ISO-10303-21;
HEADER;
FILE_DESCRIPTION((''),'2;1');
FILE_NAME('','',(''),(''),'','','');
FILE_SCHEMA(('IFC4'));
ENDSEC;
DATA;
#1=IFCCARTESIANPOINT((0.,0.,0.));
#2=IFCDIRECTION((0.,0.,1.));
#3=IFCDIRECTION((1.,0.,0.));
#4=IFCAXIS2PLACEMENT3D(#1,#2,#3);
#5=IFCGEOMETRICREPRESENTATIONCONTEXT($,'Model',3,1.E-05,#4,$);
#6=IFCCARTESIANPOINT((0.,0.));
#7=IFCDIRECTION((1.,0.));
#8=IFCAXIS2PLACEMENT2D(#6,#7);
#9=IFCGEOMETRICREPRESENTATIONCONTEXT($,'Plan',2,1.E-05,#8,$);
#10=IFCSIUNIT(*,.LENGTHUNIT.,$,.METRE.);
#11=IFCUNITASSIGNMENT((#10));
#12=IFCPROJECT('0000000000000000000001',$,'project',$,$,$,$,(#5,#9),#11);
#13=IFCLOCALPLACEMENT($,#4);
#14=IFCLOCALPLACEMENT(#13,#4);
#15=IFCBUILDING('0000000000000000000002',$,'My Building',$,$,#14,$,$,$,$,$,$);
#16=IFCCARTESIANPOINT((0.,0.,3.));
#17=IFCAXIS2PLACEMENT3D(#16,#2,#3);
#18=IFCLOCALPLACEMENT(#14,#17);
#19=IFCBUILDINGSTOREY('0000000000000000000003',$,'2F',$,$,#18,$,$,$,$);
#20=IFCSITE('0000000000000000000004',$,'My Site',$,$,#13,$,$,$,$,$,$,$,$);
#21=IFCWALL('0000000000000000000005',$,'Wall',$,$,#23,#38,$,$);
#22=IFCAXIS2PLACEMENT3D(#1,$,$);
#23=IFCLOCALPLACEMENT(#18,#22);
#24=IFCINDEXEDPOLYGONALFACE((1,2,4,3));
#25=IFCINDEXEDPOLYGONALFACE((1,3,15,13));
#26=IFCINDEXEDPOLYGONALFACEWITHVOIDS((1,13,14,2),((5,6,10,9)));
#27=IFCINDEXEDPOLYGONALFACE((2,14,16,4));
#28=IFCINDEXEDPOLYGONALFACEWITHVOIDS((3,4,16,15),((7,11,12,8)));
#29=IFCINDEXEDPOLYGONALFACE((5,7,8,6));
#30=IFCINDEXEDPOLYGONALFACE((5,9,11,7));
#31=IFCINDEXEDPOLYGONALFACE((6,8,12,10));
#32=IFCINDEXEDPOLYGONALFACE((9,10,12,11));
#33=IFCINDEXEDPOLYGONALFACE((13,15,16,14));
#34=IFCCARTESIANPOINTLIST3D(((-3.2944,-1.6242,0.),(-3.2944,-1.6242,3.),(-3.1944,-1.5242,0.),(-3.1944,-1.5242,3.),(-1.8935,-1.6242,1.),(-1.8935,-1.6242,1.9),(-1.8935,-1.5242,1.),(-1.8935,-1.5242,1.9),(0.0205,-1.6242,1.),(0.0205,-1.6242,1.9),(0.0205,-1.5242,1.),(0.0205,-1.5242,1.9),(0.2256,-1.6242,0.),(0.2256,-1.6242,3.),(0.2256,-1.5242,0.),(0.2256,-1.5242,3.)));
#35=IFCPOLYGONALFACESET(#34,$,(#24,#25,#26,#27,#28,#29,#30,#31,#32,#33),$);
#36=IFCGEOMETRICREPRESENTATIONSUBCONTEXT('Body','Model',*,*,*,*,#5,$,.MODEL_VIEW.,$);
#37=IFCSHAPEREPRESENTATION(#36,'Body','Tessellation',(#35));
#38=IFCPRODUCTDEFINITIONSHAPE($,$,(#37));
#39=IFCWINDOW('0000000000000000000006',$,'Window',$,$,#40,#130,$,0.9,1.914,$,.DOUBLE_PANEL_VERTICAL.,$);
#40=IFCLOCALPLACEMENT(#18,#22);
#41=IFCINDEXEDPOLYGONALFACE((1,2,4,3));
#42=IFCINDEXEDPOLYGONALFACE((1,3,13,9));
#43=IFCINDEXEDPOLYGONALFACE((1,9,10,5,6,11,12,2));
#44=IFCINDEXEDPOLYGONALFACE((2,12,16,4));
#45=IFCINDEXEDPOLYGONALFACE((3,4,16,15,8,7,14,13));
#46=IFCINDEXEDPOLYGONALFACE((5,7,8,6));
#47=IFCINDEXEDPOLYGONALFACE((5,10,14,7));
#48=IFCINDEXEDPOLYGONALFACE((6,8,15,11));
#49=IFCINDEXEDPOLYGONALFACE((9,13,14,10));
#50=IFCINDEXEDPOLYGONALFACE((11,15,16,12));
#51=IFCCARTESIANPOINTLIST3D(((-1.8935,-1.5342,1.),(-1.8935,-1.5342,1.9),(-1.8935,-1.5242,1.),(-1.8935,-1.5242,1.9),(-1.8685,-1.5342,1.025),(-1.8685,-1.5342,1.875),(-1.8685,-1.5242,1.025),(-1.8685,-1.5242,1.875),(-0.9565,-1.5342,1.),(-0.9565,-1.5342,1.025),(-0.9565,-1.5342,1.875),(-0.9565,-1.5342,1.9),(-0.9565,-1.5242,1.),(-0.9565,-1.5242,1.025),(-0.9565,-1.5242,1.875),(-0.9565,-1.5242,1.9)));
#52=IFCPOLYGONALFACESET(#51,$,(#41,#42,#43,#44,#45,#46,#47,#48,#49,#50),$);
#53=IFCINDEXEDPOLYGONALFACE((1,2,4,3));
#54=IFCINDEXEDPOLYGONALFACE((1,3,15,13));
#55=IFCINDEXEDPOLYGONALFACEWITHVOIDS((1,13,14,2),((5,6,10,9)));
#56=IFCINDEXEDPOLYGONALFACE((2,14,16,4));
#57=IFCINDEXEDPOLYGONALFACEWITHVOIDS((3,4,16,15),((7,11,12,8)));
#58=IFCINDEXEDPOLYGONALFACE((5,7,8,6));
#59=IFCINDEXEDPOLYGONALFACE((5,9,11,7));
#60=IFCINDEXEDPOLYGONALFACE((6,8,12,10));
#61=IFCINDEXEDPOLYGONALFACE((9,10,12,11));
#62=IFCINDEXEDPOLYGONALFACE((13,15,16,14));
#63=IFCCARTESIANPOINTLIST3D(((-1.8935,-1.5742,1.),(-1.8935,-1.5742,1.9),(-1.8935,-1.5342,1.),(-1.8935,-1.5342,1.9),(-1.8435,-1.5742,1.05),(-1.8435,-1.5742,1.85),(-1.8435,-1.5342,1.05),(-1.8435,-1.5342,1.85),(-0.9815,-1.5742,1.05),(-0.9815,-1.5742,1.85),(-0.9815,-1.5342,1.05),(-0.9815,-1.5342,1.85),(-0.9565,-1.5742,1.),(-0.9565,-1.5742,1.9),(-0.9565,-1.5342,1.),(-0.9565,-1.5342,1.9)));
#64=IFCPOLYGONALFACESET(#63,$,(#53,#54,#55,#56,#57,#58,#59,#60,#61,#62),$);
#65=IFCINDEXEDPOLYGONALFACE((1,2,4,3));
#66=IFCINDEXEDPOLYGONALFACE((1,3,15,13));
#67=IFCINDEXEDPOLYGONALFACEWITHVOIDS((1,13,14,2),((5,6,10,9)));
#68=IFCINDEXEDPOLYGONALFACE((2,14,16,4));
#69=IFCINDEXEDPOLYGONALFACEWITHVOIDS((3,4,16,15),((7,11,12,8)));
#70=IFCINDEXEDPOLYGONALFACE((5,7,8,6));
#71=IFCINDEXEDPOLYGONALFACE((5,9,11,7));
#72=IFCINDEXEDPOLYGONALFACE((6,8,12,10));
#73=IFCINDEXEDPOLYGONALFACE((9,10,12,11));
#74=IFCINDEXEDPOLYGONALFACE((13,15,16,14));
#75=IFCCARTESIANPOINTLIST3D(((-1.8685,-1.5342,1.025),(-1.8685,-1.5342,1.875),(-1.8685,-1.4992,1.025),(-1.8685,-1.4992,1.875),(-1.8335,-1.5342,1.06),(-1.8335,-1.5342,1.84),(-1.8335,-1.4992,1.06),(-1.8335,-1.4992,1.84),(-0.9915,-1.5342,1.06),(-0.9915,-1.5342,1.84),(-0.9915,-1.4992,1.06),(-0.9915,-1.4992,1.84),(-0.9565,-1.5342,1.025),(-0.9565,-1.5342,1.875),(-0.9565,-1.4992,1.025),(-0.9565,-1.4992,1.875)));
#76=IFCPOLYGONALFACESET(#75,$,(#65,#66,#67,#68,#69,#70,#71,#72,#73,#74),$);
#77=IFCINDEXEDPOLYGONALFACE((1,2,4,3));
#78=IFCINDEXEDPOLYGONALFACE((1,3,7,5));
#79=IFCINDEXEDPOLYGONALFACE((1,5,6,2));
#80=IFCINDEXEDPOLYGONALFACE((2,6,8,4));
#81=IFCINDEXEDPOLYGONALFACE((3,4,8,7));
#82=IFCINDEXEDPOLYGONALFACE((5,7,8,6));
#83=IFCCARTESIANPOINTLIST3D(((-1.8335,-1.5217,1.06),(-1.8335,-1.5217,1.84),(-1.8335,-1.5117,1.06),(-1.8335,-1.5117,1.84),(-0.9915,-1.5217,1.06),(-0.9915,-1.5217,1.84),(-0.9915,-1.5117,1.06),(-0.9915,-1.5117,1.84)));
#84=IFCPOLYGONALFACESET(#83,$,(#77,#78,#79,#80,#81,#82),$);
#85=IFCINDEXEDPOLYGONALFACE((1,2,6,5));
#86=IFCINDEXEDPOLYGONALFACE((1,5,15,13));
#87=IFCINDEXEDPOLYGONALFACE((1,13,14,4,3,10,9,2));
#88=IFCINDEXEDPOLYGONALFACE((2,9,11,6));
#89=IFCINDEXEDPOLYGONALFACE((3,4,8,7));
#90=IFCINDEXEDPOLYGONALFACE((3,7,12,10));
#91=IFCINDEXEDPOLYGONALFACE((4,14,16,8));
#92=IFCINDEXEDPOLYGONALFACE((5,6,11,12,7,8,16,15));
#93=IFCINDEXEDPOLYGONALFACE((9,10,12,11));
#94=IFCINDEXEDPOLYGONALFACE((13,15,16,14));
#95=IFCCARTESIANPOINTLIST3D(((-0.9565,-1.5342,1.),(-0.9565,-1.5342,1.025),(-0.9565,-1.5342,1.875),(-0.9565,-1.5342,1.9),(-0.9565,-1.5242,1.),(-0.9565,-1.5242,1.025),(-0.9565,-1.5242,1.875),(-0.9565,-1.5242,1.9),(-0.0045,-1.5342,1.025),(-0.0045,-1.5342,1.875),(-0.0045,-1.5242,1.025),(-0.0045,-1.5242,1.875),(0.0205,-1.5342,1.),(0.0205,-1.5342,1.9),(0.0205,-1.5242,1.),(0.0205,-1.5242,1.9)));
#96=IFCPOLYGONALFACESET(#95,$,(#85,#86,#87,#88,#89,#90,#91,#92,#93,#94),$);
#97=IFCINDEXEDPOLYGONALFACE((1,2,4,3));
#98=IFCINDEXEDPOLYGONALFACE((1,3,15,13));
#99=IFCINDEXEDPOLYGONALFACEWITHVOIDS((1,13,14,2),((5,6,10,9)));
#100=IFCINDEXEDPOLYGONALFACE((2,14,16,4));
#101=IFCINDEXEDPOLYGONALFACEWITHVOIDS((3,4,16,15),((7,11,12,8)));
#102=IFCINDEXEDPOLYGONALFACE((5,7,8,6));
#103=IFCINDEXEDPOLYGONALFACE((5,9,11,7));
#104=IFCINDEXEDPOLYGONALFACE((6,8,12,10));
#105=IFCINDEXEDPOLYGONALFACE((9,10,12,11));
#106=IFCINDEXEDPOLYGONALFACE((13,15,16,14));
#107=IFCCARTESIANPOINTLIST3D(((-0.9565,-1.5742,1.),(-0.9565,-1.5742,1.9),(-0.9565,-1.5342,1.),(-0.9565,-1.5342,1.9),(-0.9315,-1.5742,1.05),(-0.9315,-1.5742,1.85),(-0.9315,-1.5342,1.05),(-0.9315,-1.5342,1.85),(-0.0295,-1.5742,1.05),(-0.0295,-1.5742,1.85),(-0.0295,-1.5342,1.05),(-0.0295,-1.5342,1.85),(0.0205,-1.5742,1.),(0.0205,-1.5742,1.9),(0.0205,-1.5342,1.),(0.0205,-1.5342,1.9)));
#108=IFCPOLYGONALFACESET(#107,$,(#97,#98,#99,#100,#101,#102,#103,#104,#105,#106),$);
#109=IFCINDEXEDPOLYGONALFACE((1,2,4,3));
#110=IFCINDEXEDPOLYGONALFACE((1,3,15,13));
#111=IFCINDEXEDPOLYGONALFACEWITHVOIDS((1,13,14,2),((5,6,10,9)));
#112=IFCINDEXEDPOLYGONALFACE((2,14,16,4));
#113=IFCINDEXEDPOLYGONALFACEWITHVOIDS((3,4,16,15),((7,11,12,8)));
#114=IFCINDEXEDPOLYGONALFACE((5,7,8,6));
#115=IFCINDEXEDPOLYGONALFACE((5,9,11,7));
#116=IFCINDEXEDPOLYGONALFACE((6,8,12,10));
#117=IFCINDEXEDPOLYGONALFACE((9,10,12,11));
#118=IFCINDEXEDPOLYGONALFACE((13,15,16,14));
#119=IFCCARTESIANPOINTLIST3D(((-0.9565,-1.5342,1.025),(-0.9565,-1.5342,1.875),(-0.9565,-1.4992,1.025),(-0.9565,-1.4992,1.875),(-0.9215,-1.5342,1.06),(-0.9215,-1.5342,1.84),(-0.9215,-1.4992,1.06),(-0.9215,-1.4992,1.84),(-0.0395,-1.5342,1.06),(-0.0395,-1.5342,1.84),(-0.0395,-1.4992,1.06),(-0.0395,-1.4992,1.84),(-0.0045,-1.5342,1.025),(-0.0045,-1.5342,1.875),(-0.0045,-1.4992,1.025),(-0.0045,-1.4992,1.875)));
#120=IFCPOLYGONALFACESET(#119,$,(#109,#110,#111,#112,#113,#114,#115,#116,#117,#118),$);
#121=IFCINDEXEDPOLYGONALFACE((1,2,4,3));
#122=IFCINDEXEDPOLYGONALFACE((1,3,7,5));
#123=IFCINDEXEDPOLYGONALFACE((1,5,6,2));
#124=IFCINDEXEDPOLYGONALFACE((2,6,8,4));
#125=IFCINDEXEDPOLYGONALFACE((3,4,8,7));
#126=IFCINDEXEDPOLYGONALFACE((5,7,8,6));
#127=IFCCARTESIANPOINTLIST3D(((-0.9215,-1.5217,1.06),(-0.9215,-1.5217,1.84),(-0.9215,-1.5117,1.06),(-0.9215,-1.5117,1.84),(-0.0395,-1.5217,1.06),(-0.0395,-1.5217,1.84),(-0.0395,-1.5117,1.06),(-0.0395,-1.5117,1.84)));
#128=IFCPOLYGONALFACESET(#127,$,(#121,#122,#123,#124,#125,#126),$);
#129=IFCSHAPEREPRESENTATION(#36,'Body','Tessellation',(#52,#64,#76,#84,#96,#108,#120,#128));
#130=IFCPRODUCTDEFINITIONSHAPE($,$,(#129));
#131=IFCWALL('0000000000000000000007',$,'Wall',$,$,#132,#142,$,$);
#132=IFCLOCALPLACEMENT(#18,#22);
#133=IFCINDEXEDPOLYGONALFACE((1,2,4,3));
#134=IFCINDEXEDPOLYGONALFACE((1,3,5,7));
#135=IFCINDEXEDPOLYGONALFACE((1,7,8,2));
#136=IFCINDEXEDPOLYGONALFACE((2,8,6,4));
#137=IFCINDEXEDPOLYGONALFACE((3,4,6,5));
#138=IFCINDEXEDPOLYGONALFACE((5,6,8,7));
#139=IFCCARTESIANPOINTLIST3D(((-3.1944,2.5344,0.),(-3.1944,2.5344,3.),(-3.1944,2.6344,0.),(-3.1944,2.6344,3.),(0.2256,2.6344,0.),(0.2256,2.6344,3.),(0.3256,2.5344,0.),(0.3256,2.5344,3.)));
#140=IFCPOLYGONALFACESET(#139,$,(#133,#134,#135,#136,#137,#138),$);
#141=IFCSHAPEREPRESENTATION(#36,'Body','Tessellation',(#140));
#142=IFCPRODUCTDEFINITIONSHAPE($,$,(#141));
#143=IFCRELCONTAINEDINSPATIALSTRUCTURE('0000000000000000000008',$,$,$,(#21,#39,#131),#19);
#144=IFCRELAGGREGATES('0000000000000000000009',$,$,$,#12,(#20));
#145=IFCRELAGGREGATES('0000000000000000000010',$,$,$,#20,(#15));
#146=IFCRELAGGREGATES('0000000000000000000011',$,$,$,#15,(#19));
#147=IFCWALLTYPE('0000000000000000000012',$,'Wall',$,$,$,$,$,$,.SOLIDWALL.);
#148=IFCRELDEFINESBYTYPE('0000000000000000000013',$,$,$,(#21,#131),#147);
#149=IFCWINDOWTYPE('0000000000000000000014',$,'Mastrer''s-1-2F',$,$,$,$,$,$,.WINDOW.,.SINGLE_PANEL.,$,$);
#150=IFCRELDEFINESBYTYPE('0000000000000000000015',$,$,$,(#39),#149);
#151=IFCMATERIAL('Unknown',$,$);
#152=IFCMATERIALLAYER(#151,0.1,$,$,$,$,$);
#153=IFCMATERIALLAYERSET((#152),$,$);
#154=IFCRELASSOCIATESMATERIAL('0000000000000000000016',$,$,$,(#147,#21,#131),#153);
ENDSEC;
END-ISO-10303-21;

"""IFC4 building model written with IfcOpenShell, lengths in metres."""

from ifc_helpers import new_model, entity, si_unit, frame, origin_with_axes, origin_2d_with_axis, place, context, subcontext, project, spatial, line, indexed_curve, outline, extrude, shape, source, transform, mapped, material, layer, layer_set, layer_usage, type_object, type_shapes, element, fill, save


model = new_model("IFC4")

# Units and contexts
model_context = context("Model", 3, precision=1e-05, world=origin_with_axes())
plan_context = context("Plan", 2, precision=1e-05, world=origin_2d_with_axis())
body_context_1 = subcontext(model_context, "Body", "Model", "MODEL_VIEW")
body_context_2 = subcontext(plan_context, "Body", "Plan", "PLAN_VIEW")
ifc_project = project(units=[si_unit("LENGTHUNIT", "METRE")], contexts=[model_context, plan_context])

# Site, building, storey
site_placement = place(None, origin_with_axes())
site = spatial("IfcSite", under=ifc_project, at=site_placement, Name="My Site")
building_placement = place(site_placement, origin_with_axes())
building = spatial("IfcBuilding", under=site, at=building_placement, Name="My Building")
storey_placement = place(building_placement, frame((0.0, 0.0, 3.0), z_axis=(0.0, 0.0, 1.0), x_axis=(1.0, 0.0, 0.0)))
storey = spatial("IfcBuildingStorey", under=building, at=storey_placement, Name="2F")

# Shared definitions
ifc_material = material(Name="Unknown")

# Shared definitions
ifc_layer_1 = layer(ifc_material, 0.1)
ifc_layer_set_1 = layer_set([ifc_layer_1])
wall_type = type_object("IfcWallType", Name="Wall", PredefinedType="SOLIDWALL", material=ifc_layer_set_1)

# Wall, opening, window
ifc_layer_usage_1 = layer_usage(ifc_layer_set_1, "AXIS2", "POSITIVE", 0.0)
wall_1_placement = place(storey_placement, frame((-3.2944, -1.6242, 0.0), z_axis=(0.0, 0.0, 1.0), x_axis=(1.0, 0.0, 0.0)))
wall_1 = element("IfcWall", 1, at=wall_1_placement, inside=storey, type_object=wall_type, material=ifc_layer_usage_1, Name="Wall", context=body_context_1, shape_type="SweptSolid", body=[
    extrude(outline(indexed_curve([(0.0, 0.0), (0.1, 0.1), (3.52, 0.1), (3.52, 0.0)], segments=[line(1, 2, 3, 4, 1)])), origin_with_axes(), (0.0, 0.0, 1.0), 3.0),
])
shared_shape_1 = source(origin_with_axes(), body_context_1, "Body", "SweptSolid", [
    extrude(outline(indexed_curve([(0.0, 0.0), (1.914, 0.0), (1.914, 0.9), (0.0, 0.9)], segments=[line(1, 2, 3, 4, 1)])), frame((0.0, -0.6, 0.0), z_axis=(0.0, -1.0, 0.0), x_axis=(1.0, 0.0, 0.0)), (0.0, 0.0, -1.0), 1.2),
])
opening_1_placement = place(wall_1_placement, frame((1.4009, 0.0, 1.0), z_axis=(0.0, 0.0, 1.0), x_axis=(1.0, 0.0, 0.0)))
opening_1 = element("IfcOpeningElement", 2, at=opening_1_placement, cuts=wall_1, PredefinedType="OPENING", context=body_context_1, shape_type="MappedRepresentation", body=[
    mapped(shared_shape_1, transform((0.0, 0.0, 0.0), x_axis=(1.0, 0.0, 0.0), y_axis=(0.0, 1.0, 0.0), z_axis=(0.0, 0.0, 1.0), scale=1.0)),
])
window_type_1 = type_object("IfcWindowType", Name="Mastrer's-1-2F", PartitioningType="SINGLE_PANEL", PredefinedType="WINDOW")
shared_shape_2 = source(origin_with_axes(), body_context_1, "Body", "SweptSolid", [
    extrude(outline(indexed_curve([(0.937, 0.0), (0.0, 0.0), (0.0, 0.9), (0.937, 0.9), (0.937, 0.875), (0.025, 0.875), (0.025, 0.025), (0.937, 0.025)], segments=[line(1, 2, 3, 4, 5, 6, 7, 8, 1)])), frame((0.0, 0.09, 0.0), z_axis=(0.0, -1.0, 0.0), x_axis=(1.0, 0.0, 0.0)), (0.0, 0.0, -1.0), 0.01),
    extrude(outline(indexed_curve([(0.0, 0.0), (0.937, 0.0), (0.937, 0.9), (0.0, 0.9)], segments=[line(1, 2, 3, 4, 1)]), holes=[indexed_curve([(0.05, 0.05), (0.912, 0.05), (0.912, 0.85), (0.05, 0.85)], segments=[line(1, 2, 3, 4, 1)])]), frame((0.0, 0.05, 0.0), z_axis=(0.0, -1.0, 0.0), x_axis=(1.0, 0.0, 0.0)), (0.0, 0.0, -1.0), 0.04),
    extrude(outline(indexed_curve([(0.0, 0.0), (0.912, 0.0), (0.912, 0.85), (0.0, 0.85)], segments=[line(1, 2, 3, 4, 1)]), holes=[indexed_curve([(0.035, 0.035), (0.877, 0.035), (0.877, 0.815), (0.035, 0.815)], segments=[line(1, 2, 3, 4, 1)])]), frame((0.025, 0.09, 0.025), z_axis=(0.0, -1.0, 0.0), x_axis=(1.0, 0.0, 0.0)), (0.0, 0.0, -1.0), 0.035),
    extrude(outline(indexed_curve([(0.035, 0.035), (0.877, 0.035), (0.877, 0.815), (0.035, 0.815)], segments=[line(1, 2, 3, 4, 1)])), frame((0.025, 0.1025, 0.025), z_axis=(0.0, -1.0, 0.0), x_axis=(1.0, 0.0, 0.0)), (0.0, 0.0, -1.0), 0.01),
    extrude(outline(indexed_curve([(0.0, 0.9), (0.977, 0.9), (0.977, 0.0), (0.0, 0.0), (0.0, 0.025), (0.952, 0.025), (0.952, 0.875), (0.0, 0.875)], segments=[line(1, 2, 3, 4, 5, 6, 7, 8, 1)])), frame((0.937, 0.09, 0.0), z_axis=(0.0, -1.0, 0.0), x_axis=(1.0, 0.0, 0.0)), (0.0, 0.0, -1.0), 0.01),
    extrude(outline(indexed_curve([(0.0, 0.0), (0.977, 0.0), (0.977, 0.9), (0.0, 0.9)], segments=[line(1, 2, 3, 4, 1)]), holes=[indexed_curve([(0.025, 0.05), (0.927, 0.05), (0.927, 0.85), (0.025, 0.85)], segments=[line(1, 2, 3, 4, 1)])]), frame((0.937, 0.05, 0.0), z_axis=(0.0, -1.0, 0.0), x_axis=(1.0, 0.0, 0.0)), (0.0, 0.0, -1.0), 0.04),
    extrude(outline(indexed_curve([(0.0, 0.0), (0.952, 0.0), (0.952, 0.85), (0.0, 0.85)], segments=[line(1, 2, 3, 4, 1)]), holes=[indexed_curve([(0.035, 0.035), (0.917, 0.035), (0.917, 0.815), (0.035, 0.815)], segments=[line(1, 2, 3, 4, 1)])]), frame((0.937, 0.09, 0.025), z_axis=(0.0, -1.0, 0.0), x_axis=(1.0, 0.0, 0.0)), (0.0, 0.0, -1.0), 0.035),
    extrude(outline(indexed_curve([(0.035, 0.035), (0.917, 0.035), (0.917, 0.815), (0.035, 0.815)], segments=[line(1, 2, 3, 4, 1)])), frame((0.937, 0.1025, 0.025), z_axis=(0.0, -1.0, 0.0), x_axis=(1.0, 0.0, 0.0)), (0.0, 0.0, -1.0), 0.01),
])
shared_shape_3 = source(origin_with_axes(), body_context_2, "Body", "Curve2D", [
    entity("IfcIndexedPolyCurve", entity("IfcCartesianPointList2D", [[0.05, 0.05], [0.912, 0.05]])),
    entity("IfcIndexedPolyCurve", entity("IfcCartesianPointList2D", [[0.0, 0.1], [0.025, 0.1], [0.025, 0.09], [0.05, 0.09], [0.05, 0.05], [0.0, 0.05]]), [entity("IfcLineIndex", [1, 2, 3, 4, 5, 6, 1])]),
    entity("IfcIndexedPolyCurve", entity("IfcCartesianPointList2D", [[0.937, 0.1], [0.937, 0.1], [0.937, 0.09], [0.912, 0.09], [0.912, 0.05], [0.937, 0.05]])),
    entity("IfcIndexedPolyCurve", entity("IfcCartesianPointList2D", [[0.025, 0.09], [0.06, 0.09], [0.06, 0.125], [0.025, 0.125]]), [entity("IfcLineIndex", [1, 2, 3, 4, 1])]),
    entity("IfcIndexedPolyCurve", entity("IfcCartesianPointList2D", [[0.937, 0.09], [0.902, 0.09], [0.902, 0.125], [0.937, 0.125]]), [entity("IfcLineIndex", [1, 2, 3, 4, 1])]),
    entity("IfcIndexedPolyCurve", entity("IfcCartesianPointList2D", [[0.06, 0.09], [0.902, 0.09]])),
    entity("IfcIndexedPolyCurve", entity("IfcCartesianPointList2D", [[0.06, 0.125], [0.902, 0.125]])),
    entity("IfcIndexedPolyCurve", entity("IfcCartesianPointList2D", [[0.06, 0.1075], [0.902, 0.1075]])),
    entity("IfcIndexedPolyCurve", entity("IfcCartesianPointList2D", [[0.962, 0.05], [1.864, 0.05]])),
    entity("IfcIndexedPolyCurve", entity("IfcCartesianPointList2D", [[0.937, 0.1], [0.937, 0.1], [0.937, 0.09], [0.962, 0.09], [0.962, 0.05], [0.937, 0.05]])),
    entity("IfcIndexedPolyCurve", entity("IfcCartesianPointList2D", [[1.914, 0.1], [1.889, 0.1], [1.889, 0.09], [1.864, 0.09], [1.864, 0.05], [1.914, 0.05]]), [entity("IfcLineIndex", [1, 2, 3, 4, 5, 6, 1])]),
    entity("IfcIndexedPolyCurve", entity("IfcCartesianPointList2D", [[0.937, 0.09], [0.972, 0.09], [0.972, 0.125], [0.937, 0.125]]), [entity("IfcLineIndex", [1, 2, 3, 4, 1])]),
    entity("IfcIndexedPolyCurve", entity("IfcCartesianPointList2D", [[1.889, 0.09], [1.854, 0.09], [1.854, 0.125], [1.889, 0.125]]), [entity("IfcLineIndex", [1, 2, 3, 4, 1])]),
    entity("IfcIndexedPolyCurve", entity("IfcCartesianPointList2D", [[0.972, 0.09], [1.854, 0.09]])),
    entity("IfcIndexedPolyCurve", entity("IfcCartesianPointList2D", [[0.972, 0.125], [1.854, 0.125]])),
    entity("IfcIndexedPolyCurve", entity("IfcCartesianPointList2D", [[0.972, 0.1075], [1.854, 0.1075]])),
])
type_shapes(window_type_1, [shared_shape_2, shared_shape_3])
window_1_placement = place(opening_1_placement, frame((0.0, 0.0, 0.0), z_axis=(0.0, 0.0, 1.0), x_axis=(1.0, 0.0, 0.0)))
window_1 = element("IfcWindow", 3, at=window_1_placement, inside=storey, type_object=window_type_1, Name="Window", OverallHeight=0.9, OverallWidth=1.914, PartitioningType="DOUBLE_PANEL_VERTICAL", shapes=[
    shape(body_context_1, "Body", "MappedRepresentation", [mapped(shared_shape_2, transform((0.0, 0.0, 0.0), x_axis=(1.0, 0.0, 0.0), y_axis=(0.0, 1.0, 0.0), z_axis=(0.0, 0.0, 1.0), scale=1.0))]),
    shape(body_context_2, "Body", "MappedRepresentation", [mapped(shared_shape_3, transform((0.0, 0.0, 0.0), x_axis=(1.0, 0.0, 0.0), y_axis=(0.0, 1.0, 0.0), z_axis=(0.0, 0.0, 1.0), scale=1.0))]),
])
fill(opening_1, window_1)

# Wall
ifc_layer_usage_2 = layer_usage(ifc_layer_set_1, "AXIS2", "POSITIVE", 0.0)
wall_2_placement = place(storey_placement, frame((-3.1944, 2.5344, 0.0), z_axis=(0.0, 0.0, 1.0), x_axis=(1.0, 0.0, 0.0)))
element("IfcWall", 4, at=wall_2_placement, inside=storey, type_object=wall_type, material=ifc_layer_usage_2, Name="Wall", context=body_context_1, shape_type="SweptSolid", body=[
    extrude(outline(indexed_curve([(0.0, 0.0), (0.0, 0.1), (3.42, 0.1), (3.52, 0.0)], segments=[line(1, 2, 3, 4, 1)])), origin_with_axes(), (0.0, 0.0, 1.0), 3.0),
])

save(model, "model.ifc")
